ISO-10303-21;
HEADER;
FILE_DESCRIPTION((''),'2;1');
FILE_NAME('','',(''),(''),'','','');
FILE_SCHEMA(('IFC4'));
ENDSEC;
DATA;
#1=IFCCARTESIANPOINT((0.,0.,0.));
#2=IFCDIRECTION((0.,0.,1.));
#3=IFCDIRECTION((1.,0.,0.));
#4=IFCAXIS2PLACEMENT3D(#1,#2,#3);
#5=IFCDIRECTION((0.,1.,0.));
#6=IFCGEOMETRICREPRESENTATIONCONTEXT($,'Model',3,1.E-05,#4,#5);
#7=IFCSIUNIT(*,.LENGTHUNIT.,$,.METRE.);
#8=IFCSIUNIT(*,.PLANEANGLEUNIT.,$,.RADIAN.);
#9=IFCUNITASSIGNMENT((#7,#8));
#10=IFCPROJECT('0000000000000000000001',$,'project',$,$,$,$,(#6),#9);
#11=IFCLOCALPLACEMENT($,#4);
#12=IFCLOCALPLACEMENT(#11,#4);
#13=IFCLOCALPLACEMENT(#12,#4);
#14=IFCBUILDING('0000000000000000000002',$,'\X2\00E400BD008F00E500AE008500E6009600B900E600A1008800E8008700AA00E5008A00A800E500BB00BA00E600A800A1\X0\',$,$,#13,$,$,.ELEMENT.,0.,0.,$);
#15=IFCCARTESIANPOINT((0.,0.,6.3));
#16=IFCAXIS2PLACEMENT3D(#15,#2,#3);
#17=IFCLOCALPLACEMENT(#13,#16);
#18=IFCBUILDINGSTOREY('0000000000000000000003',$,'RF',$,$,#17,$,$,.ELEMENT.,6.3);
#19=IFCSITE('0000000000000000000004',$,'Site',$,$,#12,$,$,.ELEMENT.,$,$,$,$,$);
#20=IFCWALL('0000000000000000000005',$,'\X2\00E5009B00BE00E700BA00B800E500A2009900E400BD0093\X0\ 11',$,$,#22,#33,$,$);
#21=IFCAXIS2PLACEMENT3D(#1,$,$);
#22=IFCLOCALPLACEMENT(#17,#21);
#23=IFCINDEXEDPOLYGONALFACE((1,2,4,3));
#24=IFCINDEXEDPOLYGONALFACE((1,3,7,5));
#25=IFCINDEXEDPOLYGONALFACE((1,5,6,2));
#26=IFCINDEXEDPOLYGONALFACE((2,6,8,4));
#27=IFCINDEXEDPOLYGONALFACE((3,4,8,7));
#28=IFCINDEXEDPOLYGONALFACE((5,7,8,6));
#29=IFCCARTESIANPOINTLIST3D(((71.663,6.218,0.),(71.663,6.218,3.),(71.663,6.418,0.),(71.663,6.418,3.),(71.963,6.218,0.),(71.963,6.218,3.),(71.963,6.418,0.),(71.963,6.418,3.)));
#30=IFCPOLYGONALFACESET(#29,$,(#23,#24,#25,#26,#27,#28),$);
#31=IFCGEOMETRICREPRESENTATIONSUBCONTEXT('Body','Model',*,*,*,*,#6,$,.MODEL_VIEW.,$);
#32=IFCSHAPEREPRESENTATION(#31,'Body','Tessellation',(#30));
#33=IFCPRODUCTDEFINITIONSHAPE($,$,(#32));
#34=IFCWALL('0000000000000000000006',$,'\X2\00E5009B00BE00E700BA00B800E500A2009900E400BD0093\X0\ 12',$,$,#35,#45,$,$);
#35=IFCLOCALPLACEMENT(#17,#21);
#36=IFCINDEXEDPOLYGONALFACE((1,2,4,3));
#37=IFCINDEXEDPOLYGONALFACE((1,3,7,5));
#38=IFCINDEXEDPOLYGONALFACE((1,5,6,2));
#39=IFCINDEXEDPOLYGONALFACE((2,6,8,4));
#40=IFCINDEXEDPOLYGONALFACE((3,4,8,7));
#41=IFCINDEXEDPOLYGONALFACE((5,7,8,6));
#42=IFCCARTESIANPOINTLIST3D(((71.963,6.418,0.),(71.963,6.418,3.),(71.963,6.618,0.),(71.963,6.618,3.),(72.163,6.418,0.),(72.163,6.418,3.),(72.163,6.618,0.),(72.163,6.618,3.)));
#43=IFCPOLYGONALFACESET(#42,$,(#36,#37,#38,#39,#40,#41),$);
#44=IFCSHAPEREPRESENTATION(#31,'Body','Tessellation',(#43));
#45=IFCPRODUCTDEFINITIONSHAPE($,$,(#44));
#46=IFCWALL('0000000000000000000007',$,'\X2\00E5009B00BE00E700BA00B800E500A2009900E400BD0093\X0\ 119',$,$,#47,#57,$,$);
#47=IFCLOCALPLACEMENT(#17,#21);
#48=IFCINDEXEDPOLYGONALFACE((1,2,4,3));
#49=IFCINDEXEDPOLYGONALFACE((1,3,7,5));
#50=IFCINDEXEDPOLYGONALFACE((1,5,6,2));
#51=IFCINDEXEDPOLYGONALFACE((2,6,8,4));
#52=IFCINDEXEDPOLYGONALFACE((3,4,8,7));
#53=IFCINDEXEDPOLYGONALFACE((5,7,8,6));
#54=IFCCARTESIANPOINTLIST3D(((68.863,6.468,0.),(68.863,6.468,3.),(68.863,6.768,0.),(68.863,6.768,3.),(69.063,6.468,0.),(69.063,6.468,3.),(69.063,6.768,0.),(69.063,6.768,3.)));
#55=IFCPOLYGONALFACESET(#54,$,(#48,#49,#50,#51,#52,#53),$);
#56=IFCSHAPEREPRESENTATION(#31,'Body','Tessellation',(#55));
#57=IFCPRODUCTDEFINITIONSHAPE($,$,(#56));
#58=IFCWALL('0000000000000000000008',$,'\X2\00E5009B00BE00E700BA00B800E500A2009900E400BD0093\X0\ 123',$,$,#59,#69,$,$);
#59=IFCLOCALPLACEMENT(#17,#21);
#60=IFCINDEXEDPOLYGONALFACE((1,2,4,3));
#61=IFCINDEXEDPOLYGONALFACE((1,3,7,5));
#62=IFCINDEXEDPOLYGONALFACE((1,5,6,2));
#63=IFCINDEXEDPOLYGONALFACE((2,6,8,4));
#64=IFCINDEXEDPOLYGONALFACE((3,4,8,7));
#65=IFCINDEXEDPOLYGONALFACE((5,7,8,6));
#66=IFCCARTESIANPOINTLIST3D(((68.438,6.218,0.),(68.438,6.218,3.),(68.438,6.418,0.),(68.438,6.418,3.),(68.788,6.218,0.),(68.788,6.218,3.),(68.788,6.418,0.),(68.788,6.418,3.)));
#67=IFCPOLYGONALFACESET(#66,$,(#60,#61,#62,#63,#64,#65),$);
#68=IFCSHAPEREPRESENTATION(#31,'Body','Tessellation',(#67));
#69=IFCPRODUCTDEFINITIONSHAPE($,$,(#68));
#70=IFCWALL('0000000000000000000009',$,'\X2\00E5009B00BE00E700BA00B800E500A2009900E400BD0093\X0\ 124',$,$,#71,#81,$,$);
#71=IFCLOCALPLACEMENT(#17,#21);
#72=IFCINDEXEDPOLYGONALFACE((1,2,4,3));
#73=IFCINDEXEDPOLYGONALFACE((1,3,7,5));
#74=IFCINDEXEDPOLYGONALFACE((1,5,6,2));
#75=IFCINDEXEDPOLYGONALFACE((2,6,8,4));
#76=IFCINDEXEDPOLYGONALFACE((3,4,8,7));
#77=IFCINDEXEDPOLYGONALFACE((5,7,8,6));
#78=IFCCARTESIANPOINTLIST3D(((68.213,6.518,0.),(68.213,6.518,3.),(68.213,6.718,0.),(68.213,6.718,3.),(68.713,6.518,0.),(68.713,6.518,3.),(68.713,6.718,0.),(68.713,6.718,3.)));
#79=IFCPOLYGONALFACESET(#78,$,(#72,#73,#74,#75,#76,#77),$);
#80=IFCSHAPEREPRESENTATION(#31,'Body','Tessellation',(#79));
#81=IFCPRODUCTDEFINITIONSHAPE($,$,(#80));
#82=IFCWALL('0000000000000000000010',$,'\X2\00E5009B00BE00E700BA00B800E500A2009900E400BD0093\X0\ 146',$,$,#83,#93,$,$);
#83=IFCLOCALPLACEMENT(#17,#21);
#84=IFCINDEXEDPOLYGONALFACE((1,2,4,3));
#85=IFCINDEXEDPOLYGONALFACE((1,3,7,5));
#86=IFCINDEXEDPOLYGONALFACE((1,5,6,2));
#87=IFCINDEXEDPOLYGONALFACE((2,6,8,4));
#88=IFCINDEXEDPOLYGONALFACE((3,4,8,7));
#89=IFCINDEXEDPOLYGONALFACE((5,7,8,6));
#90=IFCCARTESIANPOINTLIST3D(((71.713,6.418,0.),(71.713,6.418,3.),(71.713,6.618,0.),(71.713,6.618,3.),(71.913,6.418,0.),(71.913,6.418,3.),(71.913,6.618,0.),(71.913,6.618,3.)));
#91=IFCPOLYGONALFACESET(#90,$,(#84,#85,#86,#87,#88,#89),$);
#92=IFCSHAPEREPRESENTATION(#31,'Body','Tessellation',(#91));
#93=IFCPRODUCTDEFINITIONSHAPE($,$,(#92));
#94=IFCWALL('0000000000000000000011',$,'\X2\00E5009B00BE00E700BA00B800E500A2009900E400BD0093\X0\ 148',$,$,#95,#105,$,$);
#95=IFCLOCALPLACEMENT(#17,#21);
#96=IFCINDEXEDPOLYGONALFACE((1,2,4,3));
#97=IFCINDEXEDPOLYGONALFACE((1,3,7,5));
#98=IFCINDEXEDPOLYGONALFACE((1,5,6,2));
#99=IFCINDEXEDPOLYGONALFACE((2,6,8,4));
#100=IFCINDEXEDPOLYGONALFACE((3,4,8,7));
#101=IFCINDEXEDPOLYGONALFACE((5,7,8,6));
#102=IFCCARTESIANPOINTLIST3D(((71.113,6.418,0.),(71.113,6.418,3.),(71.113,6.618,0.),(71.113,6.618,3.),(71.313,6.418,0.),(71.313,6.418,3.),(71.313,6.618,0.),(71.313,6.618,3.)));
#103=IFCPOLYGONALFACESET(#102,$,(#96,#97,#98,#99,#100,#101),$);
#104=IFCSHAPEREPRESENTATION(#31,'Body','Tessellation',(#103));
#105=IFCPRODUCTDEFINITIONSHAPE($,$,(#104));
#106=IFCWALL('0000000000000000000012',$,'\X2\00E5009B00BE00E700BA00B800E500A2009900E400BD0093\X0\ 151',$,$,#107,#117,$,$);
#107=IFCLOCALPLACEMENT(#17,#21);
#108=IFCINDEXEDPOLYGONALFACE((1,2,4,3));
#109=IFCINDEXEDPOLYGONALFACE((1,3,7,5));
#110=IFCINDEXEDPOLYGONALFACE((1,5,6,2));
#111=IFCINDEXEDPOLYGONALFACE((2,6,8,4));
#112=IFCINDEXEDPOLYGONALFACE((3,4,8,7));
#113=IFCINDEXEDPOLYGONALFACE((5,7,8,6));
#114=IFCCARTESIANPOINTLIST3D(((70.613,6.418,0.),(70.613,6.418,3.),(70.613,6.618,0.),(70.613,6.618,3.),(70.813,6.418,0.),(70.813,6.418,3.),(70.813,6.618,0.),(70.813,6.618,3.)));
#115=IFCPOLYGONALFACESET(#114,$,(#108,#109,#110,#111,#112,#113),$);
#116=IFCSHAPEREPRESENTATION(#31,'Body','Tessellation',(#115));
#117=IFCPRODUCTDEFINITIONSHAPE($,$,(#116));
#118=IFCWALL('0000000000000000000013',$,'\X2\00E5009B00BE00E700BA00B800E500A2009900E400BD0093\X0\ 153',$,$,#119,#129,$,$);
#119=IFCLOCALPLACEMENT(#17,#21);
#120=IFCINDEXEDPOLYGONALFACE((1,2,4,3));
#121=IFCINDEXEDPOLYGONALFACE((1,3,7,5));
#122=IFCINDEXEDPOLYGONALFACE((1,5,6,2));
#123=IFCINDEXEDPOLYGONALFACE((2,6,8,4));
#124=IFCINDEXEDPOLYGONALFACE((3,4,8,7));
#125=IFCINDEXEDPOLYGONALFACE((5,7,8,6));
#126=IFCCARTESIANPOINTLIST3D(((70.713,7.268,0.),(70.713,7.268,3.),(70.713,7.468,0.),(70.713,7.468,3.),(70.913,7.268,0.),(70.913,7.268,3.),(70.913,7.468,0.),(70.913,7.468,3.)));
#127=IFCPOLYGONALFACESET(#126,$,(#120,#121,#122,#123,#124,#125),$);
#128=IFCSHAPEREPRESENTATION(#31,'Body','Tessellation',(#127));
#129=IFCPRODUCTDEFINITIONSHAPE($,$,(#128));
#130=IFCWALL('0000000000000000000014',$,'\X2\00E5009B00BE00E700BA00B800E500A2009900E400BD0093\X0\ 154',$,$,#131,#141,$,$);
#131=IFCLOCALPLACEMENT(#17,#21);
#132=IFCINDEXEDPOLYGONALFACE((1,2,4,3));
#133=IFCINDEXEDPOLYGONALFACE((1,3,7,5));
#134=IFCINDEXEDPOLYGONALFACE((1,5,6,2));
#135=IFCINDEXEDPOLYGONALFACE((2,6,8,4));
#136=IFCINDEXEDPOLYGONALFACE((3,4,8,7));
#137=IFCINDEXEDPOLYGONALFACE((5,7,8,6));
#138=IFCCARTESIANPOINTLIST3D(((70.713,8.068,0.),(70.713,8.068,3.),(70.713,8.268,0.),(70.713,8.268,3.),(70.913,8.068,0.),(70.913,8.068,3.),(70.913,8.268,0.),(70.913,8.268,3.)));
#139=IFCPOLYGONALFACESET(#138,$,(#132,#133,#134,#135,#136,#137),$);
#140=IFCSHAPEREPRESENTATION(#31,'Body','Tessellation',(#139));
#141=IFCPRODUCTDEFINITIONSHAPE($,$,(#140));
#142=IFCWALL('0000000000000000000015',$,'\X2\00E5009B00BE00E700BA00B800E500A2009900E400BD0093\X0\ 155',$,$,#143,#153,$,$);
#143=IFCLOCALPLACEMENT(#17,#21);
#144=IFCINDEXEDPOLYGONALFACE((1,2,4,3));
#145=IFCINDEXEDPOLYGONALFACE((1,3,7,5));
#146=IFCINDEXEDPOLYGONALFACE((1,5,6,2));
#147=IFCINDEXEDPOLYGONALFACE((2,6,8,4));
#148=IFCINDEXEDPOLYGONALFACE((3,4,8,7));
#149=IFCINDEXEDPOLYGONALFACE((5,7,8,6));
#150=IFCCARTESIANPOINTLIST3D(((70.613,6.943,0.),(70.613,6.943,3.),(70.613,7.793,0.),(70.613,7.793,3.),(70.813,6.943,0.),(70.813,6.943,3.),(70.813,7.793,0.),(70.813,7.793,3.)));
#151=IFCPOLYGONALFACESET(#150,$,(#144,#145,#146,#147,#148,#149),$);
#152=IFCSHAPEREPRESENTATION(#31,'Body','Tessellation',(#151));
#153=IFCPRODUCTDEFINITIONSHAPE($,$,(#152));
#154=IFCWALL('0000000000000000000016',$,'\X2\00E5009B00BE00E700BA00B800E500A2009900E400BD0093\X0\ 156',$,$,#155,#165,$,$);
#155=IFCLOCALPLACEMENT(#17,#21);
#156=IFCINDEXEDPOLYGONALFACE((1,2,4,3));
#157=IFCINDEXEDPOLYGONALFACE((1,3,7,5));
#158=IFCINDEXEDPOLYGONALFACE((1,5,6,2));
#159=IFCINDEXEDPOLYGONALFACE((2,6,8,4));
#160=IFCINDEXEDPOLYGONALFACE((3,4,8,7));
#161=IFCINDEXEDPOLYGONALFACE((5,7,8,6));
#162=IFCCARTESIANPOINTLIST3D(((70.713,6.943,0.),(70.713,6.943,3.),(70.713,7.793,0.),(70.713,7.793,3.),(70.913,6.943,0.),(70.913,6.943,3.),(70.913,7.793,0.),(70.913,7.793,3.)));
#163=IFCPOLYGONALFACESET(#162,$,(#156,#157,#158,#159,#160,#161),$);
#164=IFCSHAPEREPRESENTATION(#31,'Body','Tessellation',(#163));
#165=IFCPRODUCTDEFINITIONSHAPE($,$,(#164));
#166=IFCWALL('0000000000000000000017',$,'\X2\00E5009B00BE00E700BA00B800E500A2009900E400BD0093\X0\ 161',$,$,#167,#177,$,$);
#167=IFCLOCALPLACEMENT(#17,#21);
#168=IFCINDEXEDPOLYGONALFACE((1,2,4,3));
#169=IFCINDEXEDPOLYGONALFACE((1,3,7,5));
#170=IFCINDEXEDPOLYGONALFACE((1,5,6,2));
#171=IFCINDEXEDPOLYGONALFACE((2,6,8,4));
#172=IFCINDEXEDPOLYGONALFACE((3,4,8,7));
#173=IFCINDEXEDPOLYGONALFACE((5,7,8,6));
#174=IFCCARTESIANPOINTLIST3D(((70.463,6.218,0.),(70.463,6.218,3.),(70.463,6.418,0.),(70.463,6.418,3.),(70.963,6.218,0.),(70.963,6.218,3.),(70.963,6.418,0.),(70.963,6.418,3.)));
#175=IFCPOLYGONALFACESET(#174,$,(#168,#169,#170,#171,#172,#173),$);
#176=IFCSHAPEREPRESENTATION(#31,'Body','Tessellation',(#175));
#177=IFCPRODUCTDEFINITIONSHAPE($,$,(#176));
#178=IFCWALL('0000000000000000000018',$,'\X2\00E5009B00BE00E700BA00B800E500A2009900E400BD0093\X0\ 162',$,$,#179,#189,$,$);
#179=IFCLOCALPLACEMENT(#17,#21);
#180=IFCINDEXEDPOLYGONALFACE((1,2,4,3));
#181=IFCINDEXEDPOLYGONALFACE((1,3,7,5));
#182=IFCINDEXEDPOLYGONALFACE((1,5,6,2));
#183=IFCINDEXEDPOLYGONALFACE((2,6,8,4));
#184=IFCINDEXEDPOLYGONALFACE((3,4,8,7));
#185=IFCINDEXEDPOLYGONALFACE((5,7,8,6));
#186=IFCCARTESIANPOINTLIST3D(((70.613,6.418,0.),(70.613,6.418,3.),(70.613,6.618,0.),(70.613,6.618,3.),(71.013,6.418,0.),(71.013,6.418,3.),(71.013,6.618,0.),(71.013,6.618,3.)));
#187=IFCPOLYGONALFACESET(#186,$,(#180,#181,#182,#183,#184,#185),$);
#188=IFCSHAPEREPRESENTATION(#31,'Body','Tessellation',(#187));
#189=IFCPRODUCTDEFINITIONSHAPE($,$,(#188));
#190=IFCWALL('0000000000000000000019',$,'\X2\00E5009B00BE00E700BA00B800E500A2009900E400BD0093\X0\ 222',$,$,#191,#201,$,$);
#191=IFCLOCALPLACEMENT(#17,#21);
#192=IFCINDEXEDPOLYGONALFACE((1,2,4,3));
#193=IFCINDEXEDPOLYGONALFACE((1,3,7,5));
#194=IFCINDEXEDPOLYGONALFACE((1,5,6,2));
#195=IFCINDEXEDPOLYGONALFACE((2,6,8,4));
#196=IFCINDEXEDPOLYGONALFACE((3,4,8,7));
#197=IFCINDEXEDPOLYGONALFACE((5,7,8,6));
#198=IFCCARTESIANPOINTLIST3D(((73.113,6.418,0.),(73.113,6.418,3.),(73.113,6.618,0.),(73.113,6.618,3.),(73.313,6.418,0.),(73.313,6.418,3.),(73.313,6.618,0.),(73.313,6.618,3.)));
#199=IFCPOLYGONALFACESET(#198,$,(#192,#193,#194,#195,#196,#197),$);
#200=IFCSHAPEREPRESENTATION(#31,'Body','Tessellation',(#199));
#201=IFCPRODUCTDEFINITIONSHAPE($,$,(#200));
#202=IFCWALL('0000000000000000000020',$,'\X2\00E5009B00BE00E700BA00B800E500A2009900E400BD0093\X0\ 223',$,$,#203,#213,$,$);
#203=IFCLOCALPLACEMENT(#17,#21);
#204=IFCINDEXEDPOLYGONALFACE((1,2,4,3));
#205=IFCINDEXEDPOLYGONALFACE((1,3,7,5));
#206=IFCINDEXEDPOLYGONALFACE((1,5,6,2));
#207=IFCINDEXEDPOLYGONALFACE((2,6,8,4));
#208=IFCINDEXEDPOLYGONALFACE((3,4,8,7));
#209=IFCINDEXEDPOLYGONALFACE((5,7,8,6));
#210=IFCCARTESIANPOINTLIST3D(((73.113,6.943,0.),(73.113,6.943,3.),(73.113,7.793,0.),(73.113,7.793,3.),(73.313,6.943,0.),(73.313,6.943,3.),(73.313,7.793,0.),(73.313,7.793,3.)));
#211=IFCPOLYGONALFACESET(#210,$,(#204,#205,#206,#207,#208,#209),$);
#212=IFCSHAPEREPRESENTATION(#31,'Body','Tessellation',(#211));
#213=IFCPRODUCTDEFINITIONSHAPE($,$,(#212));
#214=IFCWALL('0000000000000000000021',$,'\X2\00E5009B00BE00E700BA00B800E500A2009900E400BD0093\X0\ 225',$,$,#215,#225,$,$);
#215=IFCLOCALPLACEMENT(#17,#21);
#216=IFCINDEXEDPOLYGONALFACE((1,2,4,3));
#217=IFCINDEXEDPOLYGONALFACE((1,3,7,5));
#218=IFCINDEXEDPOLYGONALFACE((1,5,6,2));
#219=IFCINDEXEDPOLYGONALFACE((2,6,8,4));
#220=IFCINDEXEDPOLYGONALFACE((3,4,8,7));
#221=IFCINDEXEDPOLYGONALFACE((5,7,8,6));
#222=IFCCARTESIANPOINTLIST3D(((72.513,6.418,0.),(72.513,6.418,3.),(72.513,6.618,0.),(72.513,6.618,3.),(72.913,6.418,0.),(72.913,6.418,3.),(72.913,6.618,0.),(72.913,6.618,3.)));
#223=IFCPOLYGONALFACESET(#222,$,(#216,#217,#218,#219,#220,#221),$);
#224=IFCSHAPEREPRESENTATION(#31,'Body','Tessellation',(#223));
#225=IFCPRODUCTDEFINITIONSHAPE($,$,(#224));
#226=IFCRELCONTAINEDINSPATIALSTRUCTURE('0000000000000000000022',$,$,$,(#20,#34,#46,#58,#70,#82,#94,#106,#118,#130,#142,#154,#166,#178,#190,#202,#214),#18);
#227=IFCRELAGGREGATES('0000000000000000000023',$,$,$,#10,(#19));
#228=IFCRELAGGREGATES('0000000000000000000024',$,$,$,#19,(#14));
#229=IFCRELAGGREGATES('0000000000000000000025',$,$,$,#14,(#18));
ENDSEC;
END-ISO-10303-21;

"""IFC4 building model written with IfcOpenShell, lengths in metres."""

from ifc_helpers import new_model, si_unit, direction, frame, frame_2d, origin_with_axes, place, context, subcontext, project, spatial, rectangle, extrude, element, save


model = new_model("IFC4")

# Units and contexts
model_context = context("Model", 3, precision=1e-05, world=origin_with_axes(), true_north=direction((0.0, 1.0, 0.0)))
body_context = subcontext(model_context, "Body", "Model", "MODEL_VIEW")
ifc_project = project(units=[si_unit("LENGTHUNIT", "METRE"), si_unit("PLANEANGLEUNIT", "RADIAN")], contexts=[model_context])

# Site, building, storey
placement = place(None, origin_with_axes())
site_placement = place(placement, origin_with_axes())
site = spatial("IfcSite", under=ifc_project, at=site_placement, Name="Site", CompositionType="ELEMENT")
building_placement = place(site_placement, origin_with_axes())
building = spatial("IfcBuilding", under=site, at=building_placement, Name="ä½\u008få®\u0085æ\u0096¹æ¡\u0088è\u0087ªå\u008a¨å»ºæ¨¡", CompositionType="ELEMENT", ElevationOfRefHeight=0.0, ElevationOfTerrain=0.0)
storey_placement = place(building_placement, frame((0.0, 0.0, 6.3), z_axis=(0.0, 0.0, 1.0), x_axis=(1.0, 0.0, 0.0)))
storey = spatial("IfcBuildingStorey", under=building, at=storey_placement, Name="RF", CompositionType="ELEMENT", Elevation=6.3)

# Walls
wall_1_placement = place(storey_placement, frame((71.813, 6.318, 0.0), z_axis=(0.0, 0.0, 1.0), x_axis=(1.0, 0.0, 0.0)))
element("IfcWall", 1, at=wall_1_placement, inside=storey, Name="å\u009b¾çº¸å¢\u0099ä½\u0093 11", context=body_context, shape_type="SweptSolid", body=[
    extrude(rectangle(XDim=0.3, YDim=0.2, at=frame_2d((0.0, 0.0), x_axis=(1.0, 0.0, 0.0))), frame((0.0, 0.0, 0.0), z_axis=(0.0, 0.0, 1.0)), (0.0, 0.0, 1.0), 3.0),
])
wall_2_placement = place(storey_placement, frame((72.063, 6.518, 0.0), z_axis=(0.0, 0.0, 1.0), x_axis=(1.0, 0.0, 0.0)))
element("IfcWall", 2, at=wall_2_placement, inside=storey, Name="å\u009b¾çº¸å¢\u0099ä½\u0093 12", context=body_context, shape_type="SweptSolid", body=[
    extrude(rectangle(XDim=0.2, YDim=0.2, at=frame_2d((0.0, 0.0), x_axis=(1.0, 0.0, 0.0))), frame((0.0, 0.0, 0.0), z_axis=(0.0, 0.0, 1.0)), (0.0, 0.0, 1.0), 3.0),
])
wall_3_placement = place(storey_placement, frame((68.963, 6.618, 0.0), z_axis=(0.0, 0.0, 1.0), x_axis=(0.0, -1.0, 0.0)))
element("IfcWall", 3, at=wall_3_placement, inside=storey, Name="å\u009b¾çº¸å¢\u0099ä½\u0093 119", context=body_context, shape_type="SweptSolid", body=[
    extrude(rectangle(XDim=0.3, YDim=0.2, at=frame_2d((0.0, 0.0), x_axis=(1.0, 0.0, 0.0))), frame((0.0, 0.0, 0.0), z_axis=(0.0, 0.0, 1.0)), (0.0, 0.0, 1.0), 3.0),
])
wall_4_placement = place(storey_placement, frame((68.613, 6.318, 0.0), z_axis=(0.0, 0.0, 1.0), x_axis=(1.0, 0.0, 0.0)))
element("IfcWall", 4, at=wall_4_placement, inside=storey, Name="å\u009b¾çº¸å¢\u0099ä½\u0093 123", context=body_context, shape_type="SweptSolid", body=[
    extrude(rectangle(XDim=0.35, YDim=0.2, at=frame_2d((0.0, 0.0), x_axis=(1.0, 0.0, 0.0))), frame((0.0, 0.0, 0.0), z_axis=(0.0, 0.0, 1.0)), (0.0, 0.0, 1.0), 3.0),
])
wall_5_placement = place(storey_placement, frame((68.463, 6.618, 0.0), z_axis=(0.0, 0.0, 1.0), x_axis=(1.0, 0.0, 0.0)))
element("IfcWall", 5, at=wall_5_placement, inside=storey, Name="å\u009b¾çº¸å¢\u0099ä½\u0093 124", context=body_context, shape_type="SweptSolid", body=[
    extrude(rectangle(XDim=0.5, YDim=0.2, at=frame_2d((0.0, 0.0), x_axis=(1.0, 0.0, 0.0))), frame((0.0, 0.0, 0.0), z_axis=(0.0, 0.0, 1.0)), (0.0, 0.0, 1.0), 3.0),
])
for number, where, z_axis, x_axis, name in (
    (6, (71.813, 6.518, 0.0), (0.0, 0.0, 1.0), (1.0, 0.0, 0.0), "å\u009b¾çº¸å¢\u0099ä½\u0093 146"),
    (7, (71.213, 6.518, 0.0), (0.0, 0.0, 1.0), (0.0, -1.0, 0.0), "å\u009b¾çº¸å¢\u0099ä½\u0093 148"),
    (8, (70.713, 6.518, 0.0), (0.0, 0.0, 1.0), (0.0, -1.0, 0.0), "å\u009b¾çº¸å¢\u0099ä½\u0093 151"),
    (9, (70.813, 7.368, 0.0), (0.0, 0.0, 1.0), (-1.0, 0.0, 0.0), "å\u009b¾çº¸å¢\u0099ä½\u0093 153"),
    (10, (70.813, 8.168, 0.0), (0.0, 0.0, 1.0), (-1.0, 0.0, 0.0), "å\u009b¾çº¸å¢\u0099ä½\u0093 154"),
):
    element("IfcWall", number, at=place(storey_placement, frame(where, z_axis=z_axis, x_axis=x_axis)), inside=storey, Name=name, context=body_context, shape_type="SweptSolid", body=[
        extrude(rectangle(XDim=0.2, YDim=0.2, at=frame_2d((0.0, 0.0), x_axis=(1.0, 0.0, 0.0))), frame((0.0, 0.0, 0.0), z_axis=(0.0, 0.0, 1.0)), (0.0, 0.0, 1.0), 3.0),
    ])
for number, where, z_axis, x_axis, name in (
    (11, (70.713, 7.368, 0.0), (0.0, 0.0, 1.0), (0.0, -1.0, 0.0), "å\u009b¾çº¸å¢\u0099ä½\u0093 155"),
    (12, (70.813, 7.368, 0.0), (0.0, 0.0, 1.0), (0.0, -1.0, 0.0), "å\u009b¾çº¸å¢\u0099ä½\u0093 156"),
):
    element("IfcWall", number, at=place(storey_placement, frame(where, z_axis=z_axis, x_axis=x_axis)), inside=storey, Name=name, context=body_context, shape_type="SweptSolid", body=[
        extrude(rectangle(XDim=0.85, YDim=0.2, at=frame_2d((0.0, 0.0), x_axis=(1.0, 0.0, 0.0))), frame((0.0, 0.0, 0.0), z_axis=(0.0, 0.0, 1.0)), (0.0, 0.0, 1.0), 3.0),
    ])
wall_6_placement = place(storey_placement, frame((70.713, 6.318, 0.0), z_axis=(0.0, 0.0, 1.0), x_axis=(1.0, 0.0, 0.0)))
element("IfcWall", 13, at=wall_6_placement, inside=storey, Name="å\u009b¾çº¸å¢\u0099ä½\u0093 161", context=body_context, shape_type="SweptSolid", body=[
    extrude(rectangle(XDim=0.5, YDim=0.2, at=frame_2d((0.0, 0.0), x_axis=(1.0, 0.0, 0.0))), frame((0.0, 0.0, 0.0), z_axis=(0.0, 0.0, 1.0)), (0.0, 0.0, 1.0), 3.0),
])
wall_7_placement = place(storey_placement, frame((70.813, 6.518, 0.0), z_axis=(0.0, 0.0, 1.0), x_axis=(1.0, 0.0, 0.0)))
element("IfcWall", 14, at=wall_7_placement, inside=storey, Name="å\u009b¾çº¸å¢\u0099ä½\u0093 162", context=body_context, shape_type="SweptSolid", body=[
    extrude(rectangle(XDim=0.4, YDim=0.2, at=frame_2d((0.0, 0.0), x_axis=(1.0, 0.0, 0.0))), frame((0.0, 0.0, 0.0), z_axis=(0.0, 0.0, 1.0)), (0.0, 0.0, 1.0), 3.0),
])
wall_8_placement = place(storey_placement, frame((73.213, 6.518, 0.0), z_axis=(0.0, 0.0, 1.0), x_axis=(0.0, -1.0, 0.0)))
element("IfcWall", 15, at=wall_8_placement, inside=storey, Name="å\u009b¾çº¸å¢\u0099ä½\u0093 222", context=body_context, shape_type="SweptSolid", body=[
    extrude(rectangle(XDim=0.2, YDim=0.2, at=frame_2d((0.0, 0.0), x_axis=(1.0, 0.0, 0.0))), frame((0.0, 0.0, 0.0), z_axis=(0.0, 0.0, 1.0)), (0.0, 0.0, 1.0), 3.0),
])
wall_9_placement = place(storey_placement, frame((73.213, 7.368, 0.0), z_axis=(0.0, 0.0, 1.0), x_axis=(0.0, -1.0, 0.0)))
element("IfcWall", 16, at=wall_9_placement, inside=storey, Name="å\u009b¾çº¸å¢\u0099ä½\u0093 223", context=body_context, shape_type="SweptSolid", body=[
    extrude(rectangle(XDim=0.85, YDim=0.2, at=frame_2d((0.0, 0.0), x_axis=(1.0, 0.0, 0.0))), frame((0.0, 0.0, 0.0), z_axis=(0.0, 0.0, 1.0)), (0.0, 0.0, 1.0), 3.0),
])
wall_10_placement = place(storey_placement, frame((72.713, 6.518, 0.0), z_axis=(0.0, 0.0, 1.0), x_axis=(1.0, 0.0, 0.0)))
element("IfcWall", 17, at=wall_10_placement, inside=storey, Name="å\u009b¾çº¸å¢\u0099ä½\u0093 225", context=body_context, shape_type="SweptSolid", body=[
    extrude(rectangle(XDim=0.4, YDim=0.2, at=frame_2d((0.0, 0.0), x_axis=(1.0, 0.0, 0.0))), frame((0.0, 0.0, 0.0), z_axis=(0.0, 0.0, 1.0)), (0.0, 0.0, 1.0), 3.0),
])

save(model, "model.ifc")
